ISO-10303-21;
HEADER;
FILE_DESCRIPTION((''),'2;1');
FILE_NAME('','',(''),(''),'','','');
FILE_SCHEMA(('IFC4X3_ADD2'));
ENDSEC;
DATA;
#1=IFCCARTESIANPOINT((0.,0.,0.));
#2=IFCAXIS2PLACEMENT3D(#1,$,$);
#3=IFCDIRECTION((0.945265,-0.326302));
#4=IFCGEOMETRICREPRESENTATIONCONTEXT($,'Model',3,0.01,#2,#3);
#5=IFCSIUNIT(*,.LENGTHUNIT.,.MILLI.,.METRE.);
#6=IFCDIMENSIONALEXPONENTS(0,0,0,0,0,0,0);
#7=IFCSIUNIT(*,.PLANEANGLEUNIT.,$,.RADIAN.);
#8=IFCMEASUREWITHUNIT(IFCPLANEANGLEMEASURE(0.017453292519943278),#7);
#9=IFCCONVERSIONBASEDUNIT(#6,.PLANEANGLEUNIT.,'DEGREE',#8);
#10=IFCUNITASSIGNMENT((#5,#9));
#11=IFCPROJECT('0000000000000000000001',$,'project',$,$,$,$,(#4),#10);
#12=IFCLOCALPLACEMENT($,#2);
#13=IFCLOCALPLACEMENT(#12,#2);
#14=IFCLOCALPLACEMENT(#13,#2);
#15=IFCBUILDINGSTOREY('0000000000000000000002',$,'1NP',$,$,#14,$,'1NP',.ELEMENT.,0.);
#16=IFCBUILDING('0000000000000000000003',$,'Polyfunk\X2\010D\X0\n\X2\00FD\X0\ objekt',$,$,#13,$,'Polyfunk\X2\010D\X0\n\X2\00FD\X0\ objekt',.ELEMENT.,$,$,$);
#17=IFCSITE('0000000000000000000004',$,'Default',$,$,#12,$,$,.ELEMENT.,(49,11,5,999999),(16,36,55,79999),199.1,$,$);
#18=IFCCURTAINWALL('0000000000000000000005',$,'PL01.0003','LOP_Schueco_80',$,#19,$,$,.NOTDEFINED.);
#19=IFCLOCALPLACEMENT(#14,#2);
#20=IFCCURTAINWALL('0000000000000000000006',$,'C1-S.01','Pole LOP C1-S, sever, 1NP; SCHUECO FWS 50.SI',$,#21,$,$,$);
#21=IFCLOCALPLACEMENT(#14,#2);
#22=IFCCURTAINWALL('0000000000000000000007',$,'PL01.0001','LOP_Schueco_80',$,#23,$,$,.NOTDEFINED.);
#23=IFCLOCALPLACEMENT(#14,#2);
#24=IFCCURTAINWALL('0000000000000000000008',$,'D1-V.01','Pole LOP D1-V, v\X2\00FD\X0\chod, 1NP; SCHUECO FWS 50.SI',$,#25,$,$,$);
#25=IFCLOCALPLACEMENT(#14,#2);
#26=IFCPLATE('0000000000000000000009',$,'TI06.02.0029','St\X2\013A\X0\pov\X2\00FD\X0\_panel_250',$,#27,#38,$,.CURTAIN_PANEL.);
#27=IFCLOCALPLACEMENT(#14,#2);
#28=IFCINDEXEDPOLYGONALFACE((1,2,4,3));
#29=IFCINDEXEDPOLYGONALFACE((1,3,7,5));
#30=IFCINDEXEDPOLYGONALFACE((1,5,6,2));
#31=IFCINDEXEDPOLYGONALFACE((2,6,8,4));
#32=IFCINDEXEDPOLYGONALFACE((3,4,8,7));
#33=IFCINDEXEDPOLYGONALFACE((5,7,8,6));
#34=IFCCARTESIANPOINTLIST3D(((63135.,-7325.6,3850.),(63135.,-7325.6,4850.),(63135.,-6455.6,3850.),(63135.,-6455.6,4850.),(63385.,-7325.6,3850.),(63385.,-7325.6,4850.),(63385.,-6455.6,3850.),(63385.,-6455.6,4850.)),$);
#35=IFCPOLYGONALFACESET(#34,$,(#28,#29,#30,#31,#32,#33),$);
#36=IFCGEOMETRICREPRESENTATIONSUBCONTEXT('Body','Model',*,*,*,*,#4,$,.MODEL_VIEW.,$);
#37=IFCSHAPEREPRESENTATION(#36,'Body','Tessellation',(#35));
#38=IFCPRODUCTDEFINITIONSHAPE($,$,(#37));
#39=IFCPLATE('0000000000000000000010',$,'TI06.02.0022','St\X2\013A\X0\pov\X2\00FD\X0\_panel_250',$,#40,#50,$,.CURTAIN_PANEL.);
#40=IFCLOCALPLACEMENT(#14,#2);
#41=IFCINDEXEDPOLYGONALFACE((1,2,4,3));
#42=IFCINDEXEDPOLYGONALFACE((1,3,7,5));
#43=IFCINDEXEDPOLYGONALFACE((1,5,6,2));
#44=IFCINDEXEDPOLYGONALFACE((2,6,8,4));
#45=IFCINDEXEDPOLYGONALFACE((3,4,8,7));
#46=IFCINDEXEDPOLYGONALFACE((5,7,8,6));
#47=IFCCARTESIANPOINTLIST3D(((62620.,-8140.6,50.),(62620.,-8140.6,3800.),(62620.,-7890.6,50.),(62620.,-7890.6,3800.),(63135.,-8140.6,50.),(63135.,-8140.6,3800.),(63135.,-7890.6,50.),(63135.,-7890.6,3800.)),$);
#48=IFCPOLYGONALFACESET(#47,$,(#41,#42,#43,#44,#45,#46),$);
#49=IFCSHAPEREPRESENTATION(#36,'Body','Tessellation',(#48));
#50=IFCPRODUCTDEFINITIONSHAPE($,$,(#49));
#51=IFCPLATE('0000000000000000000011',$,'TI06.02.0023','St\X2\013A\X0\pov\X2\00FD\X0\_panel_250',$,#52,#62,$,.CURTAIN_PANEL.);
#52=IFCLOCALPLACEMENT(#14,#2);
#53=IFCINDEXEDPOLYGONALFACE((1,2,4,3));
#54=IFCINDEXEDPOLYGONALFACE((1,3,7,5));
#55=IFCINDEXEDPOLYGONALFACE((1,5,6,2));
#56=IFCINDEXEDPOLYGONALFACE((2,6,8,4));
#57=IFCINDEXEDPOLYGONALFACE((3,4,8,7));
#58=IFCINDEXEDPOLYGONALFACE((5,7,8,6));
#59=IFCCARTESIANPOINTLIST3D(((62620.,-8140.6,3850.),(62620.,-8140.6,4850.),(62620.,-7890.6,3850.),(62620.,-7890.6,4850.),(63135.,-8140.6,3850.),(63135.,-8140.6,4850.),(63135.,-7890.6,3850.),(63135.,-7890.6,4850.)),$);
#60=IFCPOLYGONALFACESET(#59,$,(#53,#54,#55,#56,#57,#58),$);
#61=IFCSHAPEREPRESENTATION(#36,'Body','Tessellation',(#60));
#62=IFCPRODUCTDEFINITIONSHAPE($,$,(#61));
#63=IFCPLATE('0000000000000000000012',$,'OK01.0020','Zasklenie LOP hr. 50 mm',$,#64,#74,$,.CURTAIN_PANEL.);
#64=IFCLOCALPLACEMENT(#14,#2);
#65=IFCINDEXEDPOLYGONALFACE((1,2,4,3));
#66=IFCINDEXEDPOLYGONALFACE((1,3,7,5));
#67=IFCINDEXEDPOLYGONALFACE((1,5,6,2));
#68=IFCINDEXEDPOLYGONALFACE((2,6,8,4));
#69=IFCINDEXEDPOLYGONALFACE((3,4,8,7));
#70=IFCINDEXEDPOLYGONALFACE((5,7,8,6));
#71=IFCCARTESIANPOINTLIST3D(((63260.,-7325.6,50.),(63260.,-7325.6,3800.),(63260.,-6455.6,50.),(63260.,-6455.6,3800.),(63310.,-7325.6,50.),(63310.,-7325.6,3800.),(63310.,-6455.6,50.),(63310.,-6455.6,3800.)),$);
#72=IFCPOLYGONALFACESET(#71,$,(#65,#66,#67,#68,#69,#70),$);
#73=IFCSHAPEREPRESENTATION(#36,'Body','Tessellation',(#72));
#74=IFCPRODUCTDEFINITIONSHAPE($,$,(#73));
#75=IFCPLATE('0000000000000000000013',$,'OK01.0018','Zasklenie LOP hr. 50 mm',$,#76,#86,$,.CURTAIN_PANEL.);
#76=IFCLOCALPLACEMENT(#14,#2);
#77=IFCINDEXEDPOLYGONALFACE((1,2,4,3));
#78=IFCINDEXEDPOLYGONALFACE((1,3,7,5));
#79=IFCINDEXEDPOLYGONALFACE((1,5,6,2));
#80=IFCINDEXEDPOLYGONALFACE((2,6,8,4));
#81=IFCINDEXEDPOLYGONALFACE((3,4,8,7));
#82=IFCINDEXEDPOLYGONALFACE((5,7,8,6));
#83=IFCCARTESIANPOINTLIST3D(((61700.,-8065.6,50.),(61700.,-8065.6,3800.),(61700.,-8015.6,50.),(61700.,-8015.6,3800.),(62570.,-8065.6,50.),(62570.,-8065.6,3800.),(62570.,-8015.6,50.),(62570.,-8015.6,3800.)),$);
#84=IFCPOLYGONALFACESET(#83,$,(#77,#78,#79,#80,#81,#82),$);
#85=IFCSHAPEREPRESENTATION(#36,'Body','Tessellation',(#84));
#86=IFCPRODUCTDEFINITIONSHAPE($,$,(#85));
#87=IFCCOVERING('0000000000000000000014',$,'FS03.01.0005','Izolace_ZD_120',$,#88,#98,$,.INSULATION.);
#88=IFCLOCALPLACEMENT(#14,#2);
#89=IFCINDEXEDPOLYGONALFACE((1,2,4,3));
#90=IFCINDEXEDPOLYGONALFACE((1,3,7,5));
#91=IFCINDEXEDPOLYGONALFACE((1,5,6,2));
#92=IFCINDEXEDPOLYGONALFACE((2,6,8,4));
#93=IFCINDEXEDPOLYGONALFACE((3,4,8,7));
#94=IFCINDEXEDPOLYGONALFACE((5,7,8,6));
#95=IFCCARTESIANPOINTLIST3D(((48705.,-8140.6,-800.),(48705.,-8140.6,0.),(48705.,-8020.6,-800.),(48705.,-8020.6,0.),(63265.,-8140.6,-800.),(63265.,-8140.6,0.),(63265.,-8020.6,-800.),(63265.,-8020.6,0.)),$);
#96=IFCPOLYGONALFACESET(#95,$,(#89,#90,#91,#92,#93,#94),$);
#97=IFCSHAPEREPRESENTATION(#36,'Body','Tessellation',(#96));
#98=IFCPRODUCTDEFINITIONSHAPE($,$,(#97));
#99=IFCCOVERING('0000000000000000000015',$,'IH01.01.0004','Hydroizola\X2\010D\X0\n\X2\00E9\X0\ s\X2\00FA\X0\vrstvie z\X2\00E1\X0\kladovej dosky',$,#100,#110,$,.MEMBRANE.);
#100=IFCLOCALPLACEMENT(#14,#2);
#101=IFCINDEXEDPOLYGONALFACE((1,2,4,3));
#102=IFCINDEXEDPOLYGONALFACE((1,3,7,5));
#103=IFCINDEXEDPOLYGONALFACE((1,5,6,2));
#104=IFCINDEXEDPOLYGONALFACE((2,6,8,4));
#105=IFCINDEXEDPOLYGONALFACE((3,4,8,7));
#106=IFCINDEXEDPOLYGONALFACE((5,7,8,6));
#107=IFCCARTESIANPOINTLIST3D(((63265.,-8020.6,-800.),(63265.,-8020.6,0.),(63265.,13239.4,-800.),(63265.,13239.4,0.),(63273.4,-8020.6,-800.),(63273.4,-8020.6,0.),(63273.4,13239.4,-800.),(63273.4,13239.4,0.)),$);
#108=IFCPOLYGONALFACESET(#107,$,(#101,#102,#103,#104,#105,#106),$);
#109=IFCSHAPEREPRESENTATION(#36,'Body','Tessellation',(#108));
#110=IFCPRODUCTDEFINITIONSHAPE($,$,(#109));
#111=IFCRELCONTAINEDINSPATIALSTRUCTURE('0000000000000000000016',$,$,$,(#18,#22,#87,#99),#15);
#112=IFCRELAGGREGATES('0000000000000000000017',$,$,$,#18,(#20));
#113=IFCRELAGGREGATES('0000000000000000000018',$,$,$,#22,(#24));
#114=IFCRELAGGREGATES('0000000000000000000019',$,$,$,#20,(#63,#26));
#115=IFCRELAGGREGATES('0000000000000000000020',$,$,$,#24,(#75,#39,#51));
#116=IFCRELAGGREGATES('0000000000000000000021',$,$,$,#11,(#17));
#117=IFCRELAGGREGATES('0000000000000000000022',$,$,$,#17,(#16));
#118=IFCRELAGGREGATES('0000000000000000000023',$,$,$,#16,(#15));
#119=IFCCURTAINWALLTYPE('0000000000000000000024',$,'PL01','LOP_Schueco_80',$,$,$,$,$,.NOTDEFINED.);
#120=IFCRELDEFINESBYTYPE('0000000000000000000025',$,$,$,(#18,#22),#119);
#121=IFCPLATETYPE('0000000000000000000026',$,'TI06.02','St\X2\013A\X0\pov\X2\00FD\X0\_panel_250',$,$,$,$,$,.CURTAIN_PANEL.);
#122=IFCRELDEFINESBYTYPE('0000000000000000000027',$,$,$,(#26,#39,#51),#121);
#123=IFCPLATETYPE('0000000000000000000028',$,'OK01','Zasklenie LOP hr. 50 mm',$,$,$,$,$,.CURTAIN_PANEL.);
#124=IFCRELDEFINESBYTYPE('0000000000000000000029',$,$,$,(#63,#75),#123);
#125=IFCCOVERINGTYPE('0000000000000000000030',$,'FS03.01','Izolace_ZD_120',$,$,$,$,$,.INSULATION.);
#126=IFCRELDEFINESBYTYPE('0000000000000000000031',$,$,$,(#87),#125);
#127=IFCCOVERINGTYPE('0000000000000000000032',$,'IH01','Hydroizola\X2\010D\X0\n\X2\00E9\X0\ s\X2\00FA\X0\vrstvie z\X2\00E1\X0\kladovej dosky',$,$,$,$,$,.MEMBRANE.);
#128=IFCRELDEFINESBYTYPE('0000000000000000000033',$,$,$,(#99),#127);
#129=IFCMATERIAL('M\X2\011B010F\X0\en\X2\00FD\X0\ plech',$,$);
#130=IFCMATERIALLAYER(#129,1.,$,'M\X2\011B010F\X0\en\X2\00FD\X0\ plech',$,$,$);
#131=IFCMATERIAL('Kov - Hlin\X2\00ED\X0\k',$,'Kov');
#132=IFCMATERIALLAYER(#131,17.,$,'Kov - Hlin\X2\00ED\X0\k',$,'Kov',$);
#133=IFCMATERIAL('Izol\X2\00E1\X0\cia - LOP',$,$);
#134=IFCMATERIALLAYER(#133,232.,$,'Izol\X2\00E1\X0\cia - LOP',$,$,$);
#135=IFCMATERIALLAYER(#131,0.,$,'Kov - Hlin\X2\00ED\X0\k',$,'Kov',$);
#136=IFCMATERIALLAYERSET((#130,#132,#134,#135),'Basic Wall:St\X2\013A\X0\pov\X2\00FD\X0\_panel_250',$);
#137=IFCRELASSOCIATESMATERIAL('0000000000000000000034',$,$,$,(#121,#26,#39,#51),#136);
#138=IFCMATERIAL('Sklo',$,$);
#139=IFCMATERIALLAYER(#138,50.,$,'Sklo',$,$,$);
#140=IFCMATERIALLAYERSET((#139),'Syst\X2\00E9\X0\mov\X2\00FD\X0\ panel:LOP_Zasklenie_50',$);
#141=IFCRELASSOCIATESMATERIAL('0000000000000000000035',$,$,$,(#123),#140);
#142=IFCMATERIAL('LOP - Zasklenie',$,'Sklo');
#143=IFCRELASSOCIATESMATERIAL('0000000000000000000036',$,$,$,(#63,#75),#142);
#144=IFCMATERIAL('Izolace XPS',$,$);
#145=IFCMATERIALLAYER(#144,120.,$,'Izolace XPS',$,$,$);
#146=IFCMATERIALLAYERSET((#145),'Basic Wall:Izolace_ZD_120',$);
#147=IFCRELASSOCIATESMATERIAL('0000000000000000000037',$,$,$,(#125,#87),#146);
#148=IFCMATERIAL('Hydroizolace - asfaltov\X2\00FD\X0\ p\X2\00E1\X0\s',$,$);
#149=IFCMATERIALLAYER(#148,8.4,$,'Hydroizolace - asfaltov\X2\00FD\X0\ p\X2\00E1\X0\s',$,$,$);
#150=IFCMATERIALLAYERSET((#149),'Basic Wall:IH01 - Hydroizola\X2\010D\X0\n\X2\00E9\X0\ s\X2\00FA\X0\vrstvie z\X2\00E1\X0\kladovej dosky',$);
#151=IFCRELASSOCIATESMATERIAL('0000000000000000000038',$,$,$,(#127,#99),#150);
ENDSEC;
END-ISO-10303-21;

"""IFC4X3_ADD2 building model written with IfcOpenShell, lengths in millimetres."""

from ifc_helpers import new_model, entity, si_unit, converted_unit, direction, frame, frame_2d, origin, origin_2d_with_axis, place, context, subcontext, project, spatial, rectangle, extrude, source, transform, mapped, material, layer, layer_set, layer_usage, type_object, type_shapes, element, aggregate, save


model = new_model("IFC4X3_ADD2")

# Units and contexts
model_context = context("Model", 3, precision=0.01, world=origin(), true_north=direction((0.945265, -0.326302)))
body_context = subcontext(model_context, "Body", "Model", "MODEL_VIEW")
ifc_project = project(units=[si_unit("LENGTHUNIT", "METRE", prefix="MILLI"), converted_unit("PLANEANGLEUNIT", "DEGREE", entity("IfcPlaneAngleMeasure", 0.017453292519943278), si_unit("PLANEANGLEUNIT", "RADIAN"), dimensions=[0, 0, 0, 0, 0, 0, 0])], contexts=[model_context])

# Site, building, storey
site_placement = place(None, origin())
site = spatial("IfcSite", under=ifc_project, at=site_placement, Name="Default", CompositionType="ELEMENT", RefLatitude=(49, 11, 5, 999999), RefLongitude=(16, 36, 55, 79999), RefElevation=199.1)
building_placement = place(site_placement, origin())
building = spatial("IfcBuilding", under=site, at=building_placement, Name="Polyfunkčný objekt", LongName="Polyfunkčný objekt", CompositionType="ELEMENT")
storey_placement = place(building_placement, origin())
storey = spatial("IfcBuildingStorey", under=building, at=storey_placement, Name="1NP", LongName="1NP", CompositionType="ELEMENT", Elevation=0.0)

# Curtain walls
curtain_wall_type = type_object("IfcCurtainWallType", Name="PL01", Description="LOP_Schueco_80", PredefinedType="NOTDEFINED")
curtain_wall_1_placement = place(storey_placement, origin())
curtain_wall_1 = element("IfcCurtainWall", 1, at=curtain_wall_1_placement, inside=storey, type_object=curtain_wall_type, Name="PL01.0003", Description="LOP_Schueco_80", PredefinedType="NOTDEFINED")
curtain_wall_2 = element("IfcCurtainWall", 2, Name="C1-S.01", Description="Pole LOP C1-S, sever, 1NP; SCHUECO FWS 50.SI")
aggregate(curtain_wall_1, [curtain_wall_2])
curtain_wall_3_placement = place(storey_placement, origin())
curtain_wall_3 = element("IfcCurtainWall", 3, at=curtain_wall_3_placement, inside=storey, type_object=curtain_wall_type, Name="PL01.0001", Description="LOP_Schueco_80", PredefinedType="NOTDEFINED")
curtain_wall_4 = element("IfcCurtainWall", 4, Name="D1-V.01", Description="Pole LOP D1-V, východ, 1NP; SCHUECO FWS 50.SI")
aggregate(curtain_wall_3, [curtain_wall_4])

# Plates
ifc_material_1 = material(Name="Měďený plech")
ifc_layer_1 = layer(ifc_material_1, 1.0, Name="Měďený plech")
ifc_material_2 = material(Name="Kov - Hliník", Category="Kov")
ifc_layer_2 = layer(ifc_material_2, 17.0, Name="Kov - Hliník", Category="Kov")
ifc_material_3 = material(Name="Izolácia - LOP")
ifc_layer_3 = layer(ifc_material_3, 232.0, Name="Izolácia - LOP")
ifc_layer_4 = layer(ifc_material_2, 0.0, Name="Kov - Hliník", Category="Kov")
ifc_layer_set_1 = layer_set([ifc_layer_1, ifc_layer_2, ifc_layer_3, ifc_layer_4], Name="Basic Wall:Stĺpový_panel_250")
plate_type_1 = type_object("IfcPlateType", Name="TI06.02", Description="Stĺpový_panel_250", PredefinedType="CURTAIN_PANEL", material=ifc_layer_set_1)
ifc_layer_usage_1 = layer_usage(ifc_layer_set_1, "AXIS2", "NEGATIVE", 125.0)
plate_1_placement = place(storey_placement, frame((63260.0, -6455.6, 3850.0), z_axis=(0.0, 0.0, 1.0), x_axis=(0.0, -1.0, 0.0)))
plate_1 = element("IfcPlate", 5, at=plate_1_placement, type_object=plate_type_1, material=ifc_layer_usage_1, Name="TI06.02.0029", Description="Stĺpový_panel_250", PredefinedType="CURTAIN_PANEL", context=body_context, shape_type="SweptSolid", body=[
    extrude(rectangle(XDim=250.0, YDim=870.0, at=frame_2d((0.0, 0.0), x_axis=(1.0, 0.0))), frame((435.0, 0.0, 0.0), z_axis=(0.0, 0.0, 1.0), x_axis=(0.0, 1.0, 0.0)), (0.0, 0.0, 1.0), 1000.0),
])
ifc_layer_usage_2 = layer_usage(ifc_layer_set_1, "AXIS2", "POSITIVE", -125.0)
plate_2_placement = place(storey_placement, frame((62620.0, -8015.6, 50.0)))
plate_2 = element("IfcPlate", 6, at=plate_2_placement, type_object=plate_type_1, material=ifc_layer_usage_2, Name="TI06.02.0022", Description="Stĺpový_panel_250", PredefinedType="CURTAIN_PANEL", context=body_context, shape_type="SweptSolid", body=[
    extrude(rectangle(XDim=250.0, YDim=515.0, at=origin_2d_with_axis()), frame((257.5, 0.0, 0.0), z_axis=(0.0, 0.0, 1.0), x_axis=(0.0, 1.0, 0.0)), (0.0, 0.0, 1.0), 3750.0),
])
ifc_layer_usage_3 = layer_usage(ifc_layer_set_1, "AXIS2", "POSITIVE", -125.0)
plate_3_placement = place(storey_placement, frame((62620.0, -8015.6, 3850.0)))
plate_3 = element("IfcPlate", 7, at=plate_3_placement, type_object=plate_type_1, material=ifc_layer_usage_3, Name="TI06.02.0023", Description="Stĺpový_panel_250", PredefinedType="CURTAIN_PANEL", context=body_context, shape_type="SweptSolid", body=[
    extrude(rectangle(XDim=250.0, YDim=515.0, at=origin_2d_with_axis()), frame((257.5, 0.0, 0.0), z_axis=(0.0, 0.0, 1.0), x_axis=(0.0, 1.0, 0.0)), (0.0, 0.0, 1.0), 1000.0),
])
ifc_material_4 = material(Name="LOP - Zasklenie", Category="Sklo")
ifc_material_5 = material(Name="Sklo")
ifc_layer_5 = layer(ifc_material_5, 50.0, Name="Sklo")
ifc_layer_set_2 = layer_set([ifc_layer_5], Name="Systémový panel:LOP_Zasklenie_50")
plate_type_2 = type_object("IfcPlateType", Name="OK01", Description="Zasklenie LOP hr. 50 mm", PredefinedType="CURTAIN_PANEL", material=ifc_layer_set_2)
shared_shape_1 = source(origin(), body_context, "Body", "SweptSolid", [
    extrude(rectangle(XDim=3750.0, YDim=870.0, at=frame_2d((-141.7, 0.0), x_axis=(1.0, 0.0))), frame((0.0, 0.0, 2016.7), z_axis=(0.0, 1.0, 0.0), x_axis=(0.0, 0.0, 1.0)), (0.0, 0.0, 1.0), 50.0),
])
plate_4_placement = place(curtain_wall_1_placement, frame((63260.0, -6890.6, 50.0), z_axis=(0.0, 0.0, 1.0), x_axis=(0.0, -1.0, 0.0)))
plate_4 = element("IfcPlate", 8, at=plate_4_placement, type_object=plate_type_2, material=ifc_material_4, Name="OK01.0020", Description="Zasklenie LOP hr. 50 mm", PredefinedType="CURTAIN_PANEL", context=body_context, shape_type="MappedRepresentation", body=[
    mapped(shared_shape_1, transform((0.0, 0.0, 0.0), scale=1.0)),
])
aggregate(curtain_wall_2, [plate_4, plate_1])
shared_shape_2 = source(origin(), body_context, "Body", "SweptSolid", [
    extrude(rectangle(XDim=3750.0, YDim=870.0, at=frame_2d((-331.2, 0.0), x_axis=(1.0, 0.0))), frame((0.0, -50.0, 2206.2), z_axis=(0.0, 1.0, 0.0), x_axis=(0.0, 0.0, 1.0)), (0.0, 0.0, 1.0), 50.0),
])
type_shapes(plate_type_2, [shared_shape_1, shared_shape_2])
plate_5_placement = place(curtain_wall_3_placement, frame((62135.0, -8015.6, 50.0)))
plate_5 = element("IfcPlate", 9, at=plate_5_placement, type_object=plate_type_2, material=ifc_material_4, Name="OK01.0018", Description="Zasklenie LOP hr. 50 mm", PredefinedType="CURTAIN_PANEL", context=body_context, shape_type="MappedRepresentation", body=[
    mapped(shared_shape_2, transform((0.0, 0.0, 0.0), scale=1.0)),
])
aggregate(curtain_wall_4, [plate_5, plate_2, plate_3])

# Coverings
ifc_material_6 = material(Name="Izolace XPS")
ifc_layer_6 = layer(ifc_material_6, 120.0, Name="Izolace XPS")
ifc_layer_set_3 = layer_set([ifc_layer_6], Name="Basic Wall:Izolace_ZD_120")
covering_type_1 = type_object("IfcCoveringType", Name="FS03.01", Description="Izolace_ZD_120", PredefinedType="INSULATION", material=ifc_layer_set_3)
covering_1_placement = place(storey_placement, frame((63265.0, -8080.6, -800.0), z_axis=(0.0, 0.0, 1.0), x_axis=(-1.0, 0.0, 0.0)))
element("IfcCovering", 10, at=covering_1_placement, inside=storey, type_object=covering_type_1, material=ifc_layer_set_3, Name="FS03.01.0005", Description="Izolace_ZD_120", PredefinedType="INSULATION", context=body_context, shape_type="SweptSolid", body=[
    extrude(rectangle(XDim=14560.0, YDim=120.0, at=frame_2d((7280.0, 0.0), x_axis=(-1.0, 0.0))), origin(), (0.0, 0.0, 1.0), 800.0),
])
ifc_material_7 = material(Name="Hydroizolace - asfaltový pás")
ifc_layer_7 = layer(ifc_material_7, 8.4, Name="Hydroizolace - asfaltový pás")
ifc_layer_set_4 = layer_set([ifc_layer_7], Name="Basic Wall:IH01 - Hydroizolačné súvrstvie základovej dosky")
covering_type_2 = type_object("IfcCoveringType", Name="IH01", Description="Hydroizolačné súvrstvie základovej dosky", PredefinedType="MEMBRANE", material=ifc_layer_set_4)
covering_2_placement = place(storey_placement, frame((63269.2, -8020.6, -800.0), z_axis=(0.0, 0.0, 1.0), x_axis=(0.0, 1.0, 0.0)))
element("IfcCovering", 11, at=covering_2_placement, inside=storey, type_object=covering_type_2, material=ifc_layer_set_4, Name="IH01.01.0004", Description="Hydroizolačné súvrstvie základovej dosky", PredefinedType="MEMBRANE", context=body_context, shape_type="SweptSolid", body=[
    extrude(rectangle(XDim=21260.0, YDim=8.4, at=frame_2d((10630.0, 0.0), x_axis=(-1.0, 0.0))), origin(), (0.0, 0.0, 1.0), 800.0),
])

save(model, "model.ifc")
